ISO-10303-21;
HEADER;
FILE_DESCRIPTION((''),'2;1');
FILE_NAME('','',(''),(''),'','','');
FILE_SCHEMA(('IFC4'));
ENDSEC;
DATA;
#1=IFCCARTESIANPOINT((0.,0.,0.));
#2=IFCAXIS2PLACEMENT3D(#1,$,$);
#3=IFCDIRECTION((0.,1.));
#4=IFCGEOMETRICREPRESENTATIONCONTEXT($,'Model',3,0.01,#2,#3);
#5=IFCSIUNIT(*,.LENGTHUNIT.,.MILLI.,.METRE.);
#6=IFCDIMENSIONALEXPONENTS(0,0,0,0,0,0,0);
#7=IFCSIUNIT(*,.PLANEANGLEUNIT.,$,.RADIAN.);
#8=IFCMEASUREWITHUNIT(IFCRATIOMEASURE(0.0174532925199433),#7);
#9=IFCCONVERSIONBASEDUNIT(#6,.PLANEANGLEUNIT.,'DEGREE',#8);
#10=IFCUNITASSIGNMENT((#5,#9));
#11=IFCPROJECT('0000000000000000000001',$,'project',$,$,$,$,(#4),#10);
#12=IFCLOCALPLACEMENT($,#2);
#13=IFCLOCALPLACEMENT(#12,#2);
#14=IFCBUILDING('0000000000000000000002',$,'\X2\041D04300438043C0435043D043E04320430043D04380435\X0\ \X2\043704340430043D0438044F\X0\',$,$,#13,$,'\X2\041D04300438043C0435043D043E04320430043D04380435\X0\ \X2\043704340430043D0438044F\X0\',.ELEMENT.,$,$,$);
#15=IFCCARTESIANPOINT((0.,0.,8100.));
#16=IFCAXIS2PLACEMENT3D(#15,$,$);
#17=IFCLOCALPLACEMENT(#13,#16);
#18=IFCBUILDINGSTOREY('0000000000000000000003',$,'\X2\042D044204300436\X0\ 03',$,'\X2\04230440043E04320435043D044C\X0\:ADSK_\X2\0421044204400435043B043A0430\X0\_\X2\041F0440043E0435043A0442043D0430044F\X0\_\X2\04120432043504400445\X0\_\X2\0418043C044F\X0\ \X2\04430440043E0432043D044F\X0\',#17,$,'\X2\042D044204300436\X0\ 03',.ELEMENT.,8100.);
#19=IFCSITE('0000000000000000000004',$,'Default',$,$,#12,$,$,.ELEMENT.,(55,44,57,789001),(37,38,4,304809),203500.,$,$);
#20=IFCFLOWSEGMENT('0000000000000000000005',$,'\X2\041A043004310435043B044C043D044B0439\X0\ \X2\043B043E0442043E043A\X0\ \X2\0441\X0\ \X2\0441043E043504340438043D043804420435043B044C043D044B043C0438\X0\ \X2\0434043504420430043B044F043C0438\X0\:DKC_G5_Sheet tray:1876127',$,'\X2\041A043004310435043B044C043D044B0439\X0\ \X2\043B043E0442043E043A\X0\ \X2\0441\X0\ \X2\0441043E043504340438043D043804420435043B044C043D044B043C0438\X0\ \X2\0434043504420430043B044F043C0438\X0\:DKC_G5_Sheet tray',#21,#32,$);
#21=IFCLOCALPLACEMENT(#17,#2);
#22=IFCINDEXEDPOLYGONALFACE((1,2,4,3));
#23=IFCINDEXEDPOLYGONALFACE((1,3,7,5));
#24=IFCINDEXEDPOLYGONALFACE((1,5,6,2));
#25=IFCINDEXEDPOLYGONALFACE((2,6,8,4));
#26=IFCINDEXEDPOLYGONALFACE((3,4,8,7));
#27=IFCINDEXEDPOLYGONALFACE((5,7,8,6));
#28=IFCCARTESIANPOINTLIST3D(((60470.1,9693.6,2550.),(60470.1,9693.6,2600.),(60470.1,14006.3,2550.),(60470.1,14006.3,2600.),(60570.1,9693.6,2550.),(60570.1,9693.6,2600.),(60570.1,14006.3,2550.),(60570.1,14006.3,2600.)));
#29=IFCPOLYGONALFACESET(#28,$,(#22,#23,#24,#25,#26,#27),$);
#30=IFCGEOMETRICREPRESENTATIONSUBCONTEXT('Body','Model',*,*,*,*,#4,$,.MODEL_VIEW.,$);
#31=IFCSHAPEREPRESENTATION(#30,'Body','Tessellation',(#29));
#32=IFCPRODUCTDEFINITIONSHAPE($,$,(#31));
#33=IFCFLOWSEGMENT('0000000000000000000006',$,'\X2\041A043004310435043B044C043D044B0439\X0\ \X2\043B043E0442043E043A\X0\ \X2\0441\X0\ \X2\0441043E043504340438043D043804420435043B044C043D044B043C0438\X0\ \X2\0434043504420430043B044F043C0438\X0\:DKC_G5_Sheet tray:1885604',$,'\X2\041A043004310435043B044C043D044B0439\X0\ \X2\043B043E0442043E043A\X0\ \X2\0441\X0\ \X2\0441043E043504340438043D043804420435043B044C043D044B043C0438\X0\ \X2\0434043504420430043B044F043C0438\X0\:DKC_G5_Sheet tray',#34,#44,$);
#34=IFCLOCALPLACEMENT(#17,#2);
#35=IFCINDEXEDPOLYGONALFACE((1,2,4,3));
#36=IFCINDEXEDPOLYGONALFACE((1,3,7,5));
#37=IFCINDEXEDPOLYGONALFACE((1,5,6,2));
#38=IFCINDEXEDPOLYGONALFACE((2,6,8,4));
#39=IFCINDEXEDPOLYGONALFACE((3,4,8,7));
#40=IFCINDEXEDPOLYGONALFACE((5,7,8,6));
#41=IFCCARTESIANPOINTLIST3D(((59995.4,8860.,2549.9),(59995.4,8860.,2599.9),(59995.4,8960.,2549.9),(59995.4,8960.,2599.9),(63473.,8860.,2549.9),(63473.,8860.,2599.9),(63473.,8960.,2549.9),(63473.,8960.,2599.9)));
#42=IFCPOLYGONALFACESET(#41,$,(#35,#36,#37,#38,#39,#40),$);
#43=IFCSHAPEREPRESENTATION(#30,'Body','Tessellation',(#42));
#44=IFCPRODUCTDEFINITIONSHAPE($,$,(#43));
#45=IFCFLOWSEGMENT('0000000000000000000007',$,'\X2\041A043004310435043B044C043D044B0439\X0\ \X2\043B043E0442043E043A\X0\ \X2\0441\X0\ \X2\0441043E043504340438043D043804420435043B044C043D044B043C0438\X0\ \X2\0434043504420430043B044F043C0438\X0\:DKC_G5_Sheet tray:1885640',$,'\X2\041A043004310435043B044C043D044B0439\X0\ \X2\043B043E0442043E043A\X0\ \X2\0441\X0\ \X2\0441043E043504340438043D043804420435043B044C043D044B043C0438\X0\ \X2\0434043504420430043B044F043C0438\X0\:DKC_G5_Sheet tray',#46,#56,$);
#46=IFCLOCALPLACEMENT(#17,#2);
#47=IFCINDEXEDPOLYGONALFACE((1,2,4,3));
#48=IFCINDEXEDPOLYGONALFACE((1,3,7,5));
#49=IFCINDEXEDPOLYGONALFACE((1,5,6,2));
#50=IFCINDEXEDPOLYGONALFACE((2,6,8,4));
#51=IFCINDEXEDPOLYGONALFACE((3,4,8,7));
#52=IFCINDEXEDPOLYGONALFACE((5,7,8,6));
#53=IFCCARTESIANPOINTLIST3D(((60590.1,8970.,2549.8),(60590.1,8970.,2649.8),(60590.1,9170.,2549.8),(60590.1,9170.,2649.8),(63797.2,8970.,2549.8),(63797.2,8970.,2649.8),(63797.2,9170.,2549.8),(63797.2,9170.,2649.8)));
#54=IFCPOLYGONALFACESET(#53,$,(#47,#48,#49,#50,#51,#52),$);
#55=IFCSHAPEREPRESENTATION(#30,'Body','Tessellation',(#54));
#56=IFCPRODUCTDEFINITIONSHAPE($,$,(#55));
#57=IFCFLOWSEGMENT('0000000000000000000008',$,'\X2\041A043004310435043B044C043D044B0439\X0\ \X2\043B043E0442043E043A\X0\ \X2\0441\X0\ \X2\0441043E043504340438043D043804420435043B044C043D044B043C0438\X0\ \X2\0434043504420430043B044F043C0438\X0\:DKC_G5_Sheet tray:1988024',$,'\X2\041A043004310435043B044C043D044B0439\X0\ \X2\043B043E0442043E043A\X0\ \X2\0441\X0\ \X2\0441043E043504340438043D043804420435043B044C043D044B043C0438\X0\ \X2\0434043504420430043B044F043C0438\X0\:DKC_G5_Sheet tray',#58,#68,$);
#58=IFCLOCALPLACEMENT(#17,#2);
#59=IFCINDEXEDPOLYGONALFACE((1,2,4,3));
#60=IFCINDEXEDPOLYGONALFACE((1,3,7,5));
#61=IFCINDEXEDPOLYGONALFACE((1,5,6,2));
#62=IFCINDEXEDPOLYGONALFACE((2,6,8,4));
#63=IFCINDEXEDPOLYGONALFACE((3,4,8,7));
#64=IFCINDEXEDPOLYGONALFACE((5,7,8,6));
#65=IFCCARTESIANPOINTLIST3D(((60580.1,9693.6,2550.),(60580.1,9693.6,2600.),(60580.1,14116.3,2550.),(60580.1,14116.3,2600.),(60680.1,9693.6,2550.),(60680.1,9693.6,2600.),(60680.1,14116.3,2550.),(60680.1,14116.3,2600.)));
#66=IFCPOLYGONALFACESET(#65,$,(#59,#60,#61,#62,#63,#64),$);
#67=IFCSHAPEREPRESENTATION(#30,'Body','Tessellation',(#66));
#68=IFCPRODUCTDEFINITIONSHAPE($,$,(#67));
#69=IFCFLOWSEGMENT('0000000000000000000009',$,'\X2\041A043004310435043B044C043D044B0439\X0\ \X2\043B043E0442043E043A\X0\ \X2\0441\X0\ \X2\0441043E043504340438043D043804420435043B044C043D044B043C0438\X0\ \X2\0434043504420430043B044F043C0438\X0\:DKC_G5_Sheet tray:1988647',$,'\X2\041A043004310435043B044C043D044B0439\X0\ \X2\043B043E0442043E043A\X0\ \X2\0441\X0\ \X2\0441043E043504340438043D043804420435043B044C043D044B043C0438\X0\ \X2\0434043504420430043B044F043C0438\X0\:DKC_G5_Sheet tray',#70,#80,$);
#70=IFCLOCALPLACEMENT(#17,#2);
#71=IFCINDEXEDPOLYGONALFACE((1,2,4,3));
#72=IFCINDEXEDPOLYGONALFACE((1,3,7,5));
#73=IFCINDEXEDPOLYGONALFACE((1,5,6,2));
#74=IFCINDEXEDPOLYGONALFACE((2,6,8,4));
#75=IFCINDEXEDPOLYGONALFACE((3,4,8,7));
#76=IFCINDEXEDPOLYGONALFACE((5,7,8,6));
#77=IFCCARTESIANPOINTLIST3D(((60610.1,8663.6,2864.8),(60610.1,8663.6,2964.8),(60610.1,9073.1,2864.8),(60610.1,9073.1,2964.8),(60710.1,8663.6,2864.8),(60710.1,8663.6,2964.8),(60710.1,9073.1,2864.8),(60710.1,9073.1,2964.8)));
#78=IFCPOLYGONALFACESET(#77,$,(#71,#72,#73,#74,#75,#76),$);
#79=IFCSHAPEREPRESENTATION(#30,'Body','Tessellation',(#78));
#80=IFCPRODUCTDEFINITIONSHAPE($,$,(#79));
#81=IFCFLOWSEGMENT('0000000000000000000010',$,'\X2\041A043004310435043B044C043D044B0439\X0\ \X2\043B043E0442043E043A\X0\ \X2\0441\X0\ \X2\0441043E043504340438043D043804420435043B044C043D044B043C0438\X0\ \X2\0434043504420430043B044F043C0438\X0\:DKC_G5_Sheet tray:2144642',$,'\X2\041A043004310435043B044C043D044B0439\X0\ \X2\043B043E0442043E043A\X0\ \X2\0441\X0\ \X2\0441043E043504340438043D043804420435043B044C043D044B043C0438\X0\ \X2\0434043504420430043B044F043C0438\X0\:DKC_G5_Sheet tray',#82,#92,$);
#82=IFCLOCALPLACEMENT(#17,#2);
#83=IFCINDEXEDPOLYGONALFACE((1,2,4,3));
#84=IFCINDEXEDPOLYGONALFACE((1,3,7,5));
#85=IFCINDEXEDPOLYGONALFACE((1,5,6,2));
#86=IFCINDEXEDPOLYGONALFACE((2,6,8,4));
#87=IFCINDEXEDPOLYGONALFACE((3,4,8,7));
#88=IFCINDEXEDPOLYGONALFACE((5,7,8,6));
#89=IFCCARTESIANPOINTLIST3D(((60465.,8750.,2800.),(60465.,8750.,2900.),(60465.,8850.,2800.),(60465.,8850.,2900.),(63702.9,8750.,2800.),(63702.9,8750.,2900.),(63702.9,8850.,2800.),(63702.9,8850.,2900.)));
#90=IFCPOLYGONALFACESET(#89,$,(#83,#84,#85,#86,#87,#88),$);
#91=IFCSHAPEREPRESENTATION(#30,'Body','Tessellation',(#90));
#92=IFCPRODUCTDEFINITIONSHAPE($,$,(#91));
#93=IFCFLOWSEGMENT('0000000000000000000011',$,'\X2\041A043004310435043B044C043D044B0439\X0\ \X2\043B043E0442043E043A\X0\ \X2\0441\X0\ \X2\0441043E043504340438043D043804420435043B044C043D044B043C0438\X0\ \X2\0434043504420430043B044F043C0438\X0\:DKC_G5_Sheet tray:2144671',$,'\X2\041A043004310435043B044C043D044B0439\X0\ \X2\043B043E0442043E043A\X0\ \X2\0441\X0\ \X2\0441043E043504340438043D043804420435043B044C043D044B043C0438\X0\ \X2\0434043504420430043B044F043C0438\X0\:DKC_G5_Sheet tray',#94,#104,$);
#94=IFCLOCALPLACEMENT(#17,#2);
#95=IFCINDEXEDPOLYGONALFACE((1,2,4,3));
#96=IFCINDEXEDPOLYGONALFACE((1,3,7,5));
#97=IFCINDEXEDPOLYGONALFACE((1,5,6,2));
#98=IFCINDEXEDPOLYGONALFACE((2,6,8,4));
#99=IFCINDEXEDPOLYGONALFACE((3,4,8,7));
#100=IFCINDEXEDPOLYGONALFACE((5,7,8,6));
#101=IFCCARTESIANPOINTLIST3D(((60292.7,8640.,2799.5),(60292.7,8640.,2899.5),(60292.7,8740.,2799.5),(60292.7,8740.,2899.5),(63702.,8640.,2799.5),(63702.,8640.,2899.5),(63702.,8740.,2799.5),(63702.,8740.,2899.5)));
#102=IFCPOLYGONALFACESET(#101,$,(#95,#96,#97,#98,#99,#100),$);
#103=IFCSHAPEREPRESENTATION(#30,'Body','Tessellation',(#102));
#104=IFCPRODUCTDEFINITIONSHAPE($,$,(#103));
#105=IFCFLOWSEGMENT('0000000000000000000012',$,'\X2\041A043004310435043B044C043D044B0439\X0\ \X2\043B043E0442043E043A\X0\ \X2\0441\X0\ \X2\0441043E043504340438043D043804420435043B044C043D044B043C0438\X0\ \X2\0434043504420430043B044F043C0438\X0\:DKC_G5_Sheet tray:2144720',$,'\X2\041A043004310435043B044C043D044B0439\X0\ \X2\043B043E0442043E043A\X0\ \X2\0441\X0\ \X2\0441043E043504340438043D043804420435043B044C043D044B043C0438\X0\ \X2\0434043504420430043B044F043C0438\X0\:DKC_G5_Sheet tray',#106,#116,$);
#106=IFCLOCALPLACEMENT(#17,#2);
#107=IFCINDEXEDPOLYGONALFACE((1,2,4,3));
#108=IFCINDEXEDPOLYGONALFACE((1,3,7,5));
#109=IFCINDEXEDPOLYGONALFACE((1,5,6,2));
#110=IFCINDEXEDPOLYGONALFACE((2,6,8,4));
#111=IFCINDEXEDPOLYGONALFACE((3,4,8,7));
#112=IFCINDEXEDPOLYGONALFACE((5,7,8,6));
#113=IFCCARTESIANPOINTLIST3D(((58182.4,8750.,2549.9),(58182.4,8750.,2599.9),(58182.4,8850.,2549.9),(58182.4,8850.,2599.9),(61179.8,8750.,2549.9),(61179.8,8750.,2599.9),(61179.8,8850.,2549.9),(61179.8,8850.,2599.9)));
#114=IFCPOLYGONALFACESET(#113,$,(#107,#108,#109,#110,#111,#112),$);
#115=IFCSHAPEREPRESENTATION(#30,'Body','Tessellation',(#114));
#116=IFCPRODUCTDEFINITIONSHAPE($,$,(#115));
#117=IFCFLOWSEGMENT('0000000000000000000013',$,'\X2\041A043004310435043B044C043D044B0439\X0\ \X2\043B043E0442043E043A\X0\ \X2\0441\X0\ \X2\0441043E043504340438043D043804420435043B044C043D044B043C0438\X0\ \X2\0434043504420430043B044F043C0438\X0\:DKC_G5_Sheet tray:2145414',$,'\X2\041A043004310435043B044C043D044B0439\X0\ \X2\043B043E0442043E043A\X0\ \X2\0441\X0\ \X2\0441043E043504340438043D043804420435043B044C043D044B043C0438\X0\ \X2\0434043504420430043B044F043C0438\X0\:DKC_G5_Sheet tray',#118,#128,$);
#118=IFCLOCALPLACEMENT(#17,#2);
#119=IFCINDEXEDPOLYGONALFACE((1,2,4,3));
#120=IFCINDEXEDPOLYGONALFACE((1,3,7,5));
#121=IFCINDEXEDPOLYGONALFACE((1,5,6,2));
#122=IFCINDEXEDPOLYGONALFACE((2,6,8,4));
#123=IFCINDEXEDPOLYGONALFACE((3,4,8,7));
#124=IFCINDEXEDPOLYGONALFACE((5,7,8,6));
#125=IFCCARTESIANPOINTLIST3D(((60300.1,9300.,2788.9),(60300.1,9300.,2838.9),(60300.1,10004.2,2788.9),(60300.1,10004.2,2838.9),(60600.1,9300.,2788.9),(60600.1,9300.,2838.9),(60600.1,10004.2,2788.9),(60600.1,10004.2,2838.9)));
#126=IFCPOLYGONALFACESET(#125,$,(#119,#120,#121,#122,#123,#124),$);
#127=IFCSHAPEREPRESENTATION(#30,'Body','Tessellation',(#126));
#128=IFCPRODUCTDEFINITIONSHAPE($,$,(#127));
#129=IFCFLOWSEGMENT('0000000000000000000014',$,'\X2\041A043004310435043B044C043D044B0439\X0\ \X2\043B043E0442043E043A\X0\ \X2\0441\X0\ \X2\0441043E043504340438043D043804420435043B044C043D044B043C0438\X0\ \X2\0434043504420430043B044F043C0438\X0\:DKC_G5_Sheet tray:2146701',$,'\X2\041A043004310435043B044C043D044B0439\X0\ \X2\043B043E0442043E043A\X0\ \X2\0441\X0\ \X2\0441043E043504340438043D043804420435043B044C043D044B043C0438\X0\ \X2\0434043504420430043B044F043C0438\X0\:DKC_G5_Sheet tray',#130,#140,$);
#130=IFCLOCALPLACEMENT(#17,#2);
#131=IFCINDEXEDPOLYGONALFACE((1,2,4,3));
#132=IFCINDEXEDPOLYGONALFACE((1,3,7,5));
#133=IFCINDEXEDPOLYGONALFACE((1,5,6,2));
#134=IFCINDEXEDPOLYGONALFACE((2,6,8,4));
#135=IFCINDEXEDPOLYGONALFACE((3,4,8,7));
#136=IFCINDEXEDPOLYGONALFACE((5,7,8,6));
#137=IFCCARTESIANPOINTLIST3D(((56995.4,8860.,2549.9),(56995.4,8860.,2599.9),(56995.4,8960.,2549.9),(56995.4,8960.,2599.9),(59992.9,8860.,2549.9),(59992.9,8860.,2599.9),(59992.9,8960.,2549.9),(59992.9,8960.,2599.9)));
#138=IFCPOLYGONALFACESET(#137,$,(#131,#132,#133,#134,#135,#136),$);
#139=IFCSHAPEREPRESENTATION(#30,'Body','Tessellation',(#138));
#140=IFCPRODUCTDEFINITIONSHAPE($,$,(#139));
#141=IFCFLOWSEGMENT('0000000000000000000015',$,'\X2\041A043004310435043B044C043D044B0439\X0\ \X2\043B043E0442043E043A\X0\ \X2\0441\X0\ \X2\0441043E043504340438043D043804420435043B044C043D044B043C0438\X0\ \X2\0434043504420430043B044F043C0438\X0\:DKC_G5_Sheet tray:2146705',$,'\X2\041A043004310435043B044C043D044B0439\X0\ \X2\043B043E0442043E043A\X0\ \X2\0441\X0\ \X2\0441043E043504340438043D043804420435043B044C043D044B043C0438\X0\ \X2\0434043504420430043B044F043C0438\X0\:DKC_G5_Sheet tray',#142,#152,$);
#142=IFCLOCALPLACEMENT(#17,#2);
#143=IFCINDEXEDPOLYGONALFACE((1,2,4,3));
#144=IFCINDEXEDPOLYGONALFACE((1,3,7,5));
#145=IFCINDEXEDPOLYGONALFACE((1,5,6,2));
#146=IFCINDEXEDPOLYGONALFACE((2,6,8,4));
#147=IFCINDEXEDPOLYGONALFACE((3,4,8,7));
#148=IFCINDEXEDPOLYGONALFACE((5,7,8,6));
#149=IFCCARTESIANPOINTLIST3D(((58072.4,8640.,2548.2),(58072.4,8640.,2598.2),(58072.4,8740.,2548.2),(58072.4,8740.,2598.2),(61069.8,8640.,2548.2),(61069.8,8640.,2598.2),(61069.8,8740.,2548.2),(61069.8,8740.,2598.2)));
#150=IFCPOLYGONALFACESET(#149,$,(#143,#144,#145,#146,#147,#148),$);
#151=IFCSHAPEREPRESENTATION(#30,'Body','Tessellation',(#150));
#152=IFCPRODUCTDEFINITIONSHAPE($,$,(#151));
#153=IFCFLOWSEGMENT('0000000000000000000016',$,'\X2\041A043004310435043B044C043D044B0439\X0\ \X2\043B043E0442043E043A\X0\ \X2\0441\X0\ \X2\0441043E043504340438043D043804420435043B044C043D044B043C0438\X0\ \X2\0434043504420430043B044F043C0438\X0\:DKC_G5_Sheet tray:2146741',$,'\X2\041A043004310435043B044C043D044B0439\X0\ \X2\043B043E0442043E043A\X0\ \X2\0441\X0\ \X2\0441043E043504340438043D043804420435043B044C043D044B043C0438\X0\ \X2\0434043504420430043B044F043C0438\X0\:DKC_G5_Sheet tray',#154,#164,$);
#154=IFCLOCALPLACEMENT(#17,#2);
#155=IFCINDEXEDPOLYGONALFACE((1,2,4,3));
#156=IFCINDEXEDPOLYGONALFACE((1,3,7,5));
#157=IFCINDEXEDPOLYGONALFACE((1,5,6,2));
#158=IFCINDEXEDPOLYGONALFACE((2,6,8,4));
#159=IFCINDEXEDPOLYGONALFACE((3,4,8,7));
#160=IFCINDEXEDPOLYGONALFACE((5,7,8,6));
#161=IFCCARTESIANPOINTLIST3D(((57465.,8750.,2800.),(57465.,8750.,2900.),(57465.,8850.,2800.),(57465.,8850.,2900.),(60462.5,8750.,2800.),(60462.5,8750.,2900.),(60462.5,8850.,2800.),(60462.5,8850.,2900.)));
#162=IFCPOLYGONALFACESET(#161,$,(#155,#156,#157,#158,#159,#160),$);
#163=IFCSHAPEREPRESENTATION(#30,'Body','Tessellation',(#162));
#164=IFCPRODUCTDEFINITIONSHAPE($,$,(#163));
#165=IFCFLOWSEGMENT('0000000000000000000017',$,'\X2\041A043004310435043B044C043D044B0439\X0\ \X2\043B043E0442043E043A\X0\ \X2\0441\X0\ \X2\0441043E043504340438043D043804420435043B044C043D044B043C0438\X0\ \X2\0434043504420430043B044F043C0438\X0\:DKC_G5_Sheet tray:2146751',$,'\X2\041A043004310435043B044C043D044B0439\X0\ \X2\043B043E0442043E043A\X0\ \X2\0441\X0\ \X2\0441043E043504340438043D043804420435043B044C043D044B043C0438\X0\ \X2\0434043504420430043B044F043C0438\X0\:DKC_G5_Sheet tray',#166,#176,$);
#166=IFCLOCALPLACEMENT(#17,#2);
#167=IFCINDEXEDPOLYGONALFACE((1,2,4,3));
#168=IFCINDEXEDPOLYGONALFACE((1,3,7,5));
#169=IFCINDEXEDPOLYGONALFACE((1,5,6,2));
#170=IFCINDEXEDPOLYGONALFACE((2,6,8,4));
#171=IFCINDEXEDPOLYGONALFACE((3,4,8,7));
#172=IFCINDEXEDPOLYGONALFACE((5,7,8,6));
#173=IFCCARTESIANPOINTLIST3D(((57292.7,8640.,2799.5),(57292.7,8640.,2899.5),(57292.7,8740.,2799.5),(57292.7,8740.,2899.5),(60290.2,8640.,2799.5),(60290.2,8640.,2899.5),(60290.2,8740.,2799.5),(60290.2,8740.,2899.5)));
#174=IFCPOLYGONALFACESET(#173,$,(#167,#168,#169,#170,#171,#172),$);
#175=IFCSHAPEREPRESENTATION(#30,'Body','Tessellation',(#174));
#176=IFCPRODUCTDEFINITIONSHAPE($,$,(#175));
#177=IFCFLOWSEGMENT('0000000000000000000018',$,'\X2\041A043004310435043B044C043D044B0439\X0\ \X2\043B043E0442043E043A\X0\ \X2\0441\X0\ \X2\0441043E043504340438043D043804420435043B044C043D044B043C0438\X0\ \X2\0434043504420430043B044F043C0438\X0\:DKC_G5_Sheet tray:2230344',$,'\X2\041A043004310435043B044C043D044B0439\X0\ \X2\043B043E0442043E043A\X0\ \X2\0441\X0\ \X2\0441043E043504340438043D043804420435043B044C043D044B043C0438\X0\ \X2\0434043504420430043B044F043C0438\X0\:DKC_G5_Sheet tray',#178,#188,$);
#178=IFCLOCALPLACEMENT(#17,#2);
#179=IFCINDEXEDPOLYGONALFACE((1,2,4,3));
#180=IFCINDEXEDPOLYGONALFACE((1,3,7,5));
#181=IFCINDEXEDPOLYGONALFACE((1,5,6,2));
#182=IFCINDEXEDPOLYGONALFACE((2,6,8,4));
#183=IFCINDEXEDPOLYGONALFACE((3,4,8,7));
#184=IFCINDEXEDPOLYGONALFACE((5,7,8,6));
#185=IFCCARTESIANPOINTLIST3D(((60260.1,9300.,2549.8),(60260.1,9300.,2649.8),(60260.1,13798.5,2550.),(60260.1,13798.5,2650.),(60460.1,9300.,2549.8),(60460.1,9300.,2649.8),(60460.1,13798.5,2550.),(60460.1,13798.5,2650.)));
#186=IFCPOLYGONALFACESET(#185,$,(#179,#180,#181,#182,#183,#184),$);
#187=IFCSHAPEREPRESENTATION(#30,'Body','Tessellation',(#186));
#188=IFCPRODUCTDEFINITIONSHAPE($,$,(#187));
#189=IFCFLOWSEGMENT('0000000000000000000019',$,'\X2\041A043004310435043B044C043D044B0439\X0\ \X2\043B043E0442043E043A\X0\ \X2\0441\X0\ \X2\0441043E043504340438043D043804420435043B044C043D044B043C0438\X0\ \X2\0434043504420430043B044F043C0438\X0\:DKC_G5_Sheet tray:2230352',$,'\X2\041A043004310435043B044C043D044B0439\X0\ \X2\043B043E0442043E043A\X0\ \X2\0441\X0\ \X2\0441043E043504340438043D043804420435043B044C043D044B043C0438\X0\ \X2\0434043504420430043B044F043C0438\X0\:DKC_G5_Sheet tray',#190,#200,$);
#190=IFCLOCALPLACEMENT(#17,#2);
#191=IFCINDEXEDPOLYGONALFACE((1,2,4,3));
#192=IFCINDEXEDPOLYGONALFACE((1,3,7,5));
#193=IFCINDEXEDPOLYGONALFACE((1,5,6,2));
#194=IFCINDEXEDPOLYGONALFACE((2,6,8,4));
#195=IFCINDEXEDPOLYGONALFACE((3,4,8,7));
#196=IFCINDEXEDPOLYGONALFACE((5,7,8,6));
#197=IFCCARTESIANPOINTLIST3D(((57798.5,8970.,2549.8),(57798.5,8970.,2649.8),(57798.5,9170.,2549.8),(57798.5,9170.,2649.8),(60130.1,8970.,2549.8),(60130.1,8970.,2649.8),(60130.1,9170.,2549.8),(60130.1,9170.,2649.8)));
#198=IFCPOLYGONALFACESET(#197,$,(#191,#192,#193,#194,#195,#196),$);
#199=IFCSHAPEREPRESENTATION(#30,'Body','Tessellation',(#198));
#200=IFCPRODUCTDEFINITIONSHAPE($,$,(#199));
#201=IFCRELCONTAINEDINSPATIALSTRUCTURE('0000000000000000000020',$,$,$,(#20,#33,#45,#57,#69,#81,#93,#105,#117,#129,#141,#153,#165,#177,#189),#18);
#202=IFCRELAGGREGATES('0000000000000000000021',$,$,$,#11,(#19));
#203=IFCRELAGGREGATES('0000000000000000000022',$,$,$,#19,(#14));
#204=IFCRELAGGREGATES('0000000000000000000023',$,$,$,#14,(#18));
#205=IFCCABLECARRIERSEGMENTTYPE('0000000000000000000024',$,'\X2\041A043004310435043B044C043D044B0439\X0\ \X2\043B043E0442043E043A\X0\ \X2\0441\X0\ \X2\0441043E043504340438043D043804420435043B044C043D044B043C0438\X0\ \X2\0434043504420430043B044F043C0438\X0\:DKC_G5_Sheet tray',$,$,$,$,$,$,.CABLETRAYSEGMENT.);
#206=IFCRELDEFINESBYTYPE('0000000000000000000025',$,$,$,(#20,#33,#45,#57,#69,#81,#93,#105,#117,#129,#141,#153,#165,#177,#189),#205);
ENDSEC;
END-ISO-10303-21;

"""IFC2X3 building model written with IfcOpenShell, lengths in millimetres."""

from ifc_helpers import new_model, entity, si_unit, converted_unit, direction, frame, origin, origin_2d_with_axis, place, context, subcontext, project, spatial, rectangle, extrude, type_object, element, save


model = new_model("IFC2X3")

# Units and contexts
model_context = context("Model", 3, precision=0.01, world=origin(), true_north=direction((0.0, 1.0)))
body_context = subcontext(model_context, "Body", "Model", "MODEL_VIEW")
ifc_project = project(units=[si_unit("LENGTHUNIT", "METRE", prefix="MILLI"), converted_unit("PLANEANGLEUNIT", "DEGREE", entity("IfcRatioMeasure", 0.0174532925199433), si_unit("PLANEANGLEUNIT", "RADIAN"), dimensions=[0, 0, 0, 0, 0, 0, 0])], contexts=[model_context])

# Site, building, storey
site_placement = place(None, origin())
site = spatial("IfcSite", under=ifc_project, at=site_placement, Name="Default", CompositionType="ELEMENT", RefLatitude=(55, 44, 57, 789001), RefLongitude=(37, 38, 4, 304809), RefElevation=203500.0)
building_placement = place(site_placement, origin())
building = spatial("IfcBuilding", under=site, at=building_placement, Name="Наименование здания", LongName="Наименование здания", CompositionType="ELEMENT")
storey_placement = place(building_placement, frame((0.0, 0.0, 8100.0)))
storey = spatial("IfcBuildingStorey", under=building, at=storey_placement, Name="Этаж 03", ObjectType="Уровень:ADSK_Стрелка_Проектная_Вверх_Имя уровня", LongName="Этаж 03", CompositionType="ELEMENT", Elevation=8100.0)

# Flow segments
cable_carrier_segment_type = type_object("IfcCableCarrierSegmentType", Name="Кабельный лоток с соединительными деталями:DKC_G5_Sheet tray", PredefinedType="CABLETRAYSEGMENT")
flow_segment_1_placement = place(storey_placement, frame((60470.1, 9693.6, 2550.0)))
element("IfcFlowSegment", 1, at=flow_segment_1_placement, inside=storey, type_object=cable_carrier_segment_type, Name="Кабельный лоток с соединительными деталями:DKC_G5_Sheet tray:1876127", ObjectType="Кабельный лоток с соединительными деталями:DKC_G5_Sheet tray", context=body_context, shape_type="SweptSolid", body=[
    extrude(rectangle(XDim=4312.7, YDim=100.0, at=origin_2d_with_axis()), frame((50.0, 2156.3, 0.0), z_axis=(0.0, 0.0, 1.0), x_axis=(0.0, -1.0, 0.0)), (0.0, 0.0, 1.0), 50.0),
])
flow_segment_2_placement = place(storey_placement, frame((59995.4, 8860.0, 2549.9)))
element("IfcFlowSegment", 2, at=flow_segment_2_placement, inside=storey, type_object=cable_carrier_segment_type, Name="Кабельный лоток с соединительными деталями:DKC_G5_Sheet tray:1885604", ObjectType="Кабельный лоток с соединительными деталями:DKC_G5_Sheet tray", context=body_context, shape_type="SweptSolid", body=[
    extrude(rectangle(XDim=3477.6, YDim=100.0, at=origin_2d_with_axis()), frame((1738.8, 50.0, 0.0), z_axis=(0.0, 0.0, 1.0), x_axis=(-1.0, 0.0, 0.0)), (0.0, 0.0, 1.0), 50.0),
])
flow_segment_3_placement = place(storey_placement, frame((60590.1, 8970.0, 2549.8)))
element("IfcFlowSegment", 3, at=flow_segment_3_placement, inside=storey, type_object=cable_carrier_segment_type, Name="Кабельный лоток с соединительными деталями:DKC_G5_Sheet tray:1885640", ObjectType="Кабельный лоток с соединительными деталями:DKC_G5_Sheet tray", context=body_context, shape_type="SweptSolid", body=[
    extrude(rectangle(XDim=3207.1, YDim=200.0, at=origin_2d_with_axis()), frame((1603.5, 100.0, 0.0)), (0.0, 0.0, 1.0), 100.0),
])
flow_segment_4_placement = place(storey_placement, frame((60580.1, 9693.6, 2550.0)))
element("IfcFlowSegment", 4, at=flow_segment_4_placement, inside=storey, type_object=cable_carrier_segment_type, Name="Кабельный лоток с соединительными деталями:DKC_G5_Sheet tray:1988024", ObjectType="Кабельный лоток с соединительными деталями:DKC_G5_Sheet tray", context=body_context, shape_type="SweptSolid", body=[
    extrude(rectangle(XDim=4422.7, YDim=100.0, at=origin_2d_with_axis()), frame((50.0, 2211.3, 0.0), z_axis=(0.0, 0.0, 1.0), x_axis=(0.0, -1.0, 0.0)), (0.0, 0.0, 1.0), 50.0),
])
flow_segment_5_placement = place(storey_placement, frame((60610.1, 8663.6, 2864.8)))
element("IfcFlowSegment", 5, at=flow_segment_5_placement, inside=storey, type_object=cable_carrier_segment_type, Name="Кабельный лоток с соединительными деталями:DKC_G5_Sheet tray:1988647", ObjectType="Кабельный лоток с соединительными деталями:DKC_G5_Sheet tray", context=body_context, shape_type="SweptSolid", body=[
    extrude(rectangle(XDim=409.5, YDim=100.0, at=origin_2d_with_axis()), frame((50.0, 204.8, 0.0), z_axis=(0.0, 0.0, 1.0), x_axis=(0.0, -1.0, 0.0)), (0.0, 0.0, 1.0), 100.0),
])
flow_segment_6_placement = place(storey_placement, frame((60465.0, 8750.0, 2800.0)))
element("IfcFlowSegment", 6, at=flow_segment_6_placement, inside=storey, type_object=cable_carrier_segment_type, Name="Кабельный лоток с соединительными деталями:DKC_G5_Sheet tray:2144642", ObjectType="Кабельный лоток с соединительными деталями:DKC_G5_Sheet tray", context=body_context, shape_type="SweptSolid", body=[
    extrude(rectangle(XDim=3237.8, YDim=100.0, at=origin_2d_with_axis()), frame((1618.9, 50.0, 0.0), z_axis=(0.000001, 0.000012, 1.0), x_axis=(-1.0, 0.0, 0.000001)), (0.0, 0.0, 1.0), 100.0),
])
flow_segment_7_placement = place(storey_placement, frame((60292.7, 8640.0, 2799.5)))
element("IfcFlowSegment", 7, at=flow_segment_7_placement, inside=storey, type_object=cable_carrier_segment_type, Name="Кабельный лоток с соединительными деталями:DKC_G5_Sheet tray:2144671", ObjectType="Кабельный лоток с соединительными деталями:DKC_G5_Sheet tray", context=body_context, shape_type="SweptSolid", body=[
    extrude(rectangle(XDim=3409.3, YDim=100.0, at=origin_2d_with_axis()), frame((1704.6, 50.0, 0.0), z_axis=(0.0, -0.000024, 1.0), x_axis=(-1.0, 0.0, 0.0)), (0.0, 0.0, 1.0), 100.0),
])
flow_segment_8_placement = place(storey_placement, frame((58182.4, 8750.0, 2549.9)))
element("IfcFlowSegment", 8, at=flow_segment_8_placement, inside=storey, type_object=cable_carrier_segment_type, Name="Кабельный лоток с соединительными деталями:DKC_G5_Sheet tray:2144720", ObjectType="Кабельный лоток с соединительными деталями:DKC_G5_Sheet tray", context=body_context, shape_type="SweptSolid", body=[
    extrude(rectangle(XDim=2997.5, YDim=100.0, at=origin_2d_with_axis()), frame((1498.7, 50.0, 0.0)), (0.0, 0.0, 1.0), 50.0),
])
flow_segment_9_placement = place(storey_placement, frame((60300.1, 9300.0, 2788.9)))
element("IfcFlowSegment", 9, at=flow_segment_9_placement, inside=storey, type_object=cable_carrier_segment_type, Name="Кабельный лоток с соединительными деталями:DKC_G5_Sheet tray:2145414", ObjectType="Кабельный лоток с соединительными деталями:DKC_G5_Sheet tray", context=body_context, shape_type="SweptSolid", body=[
    extrude(rectangle(XDim=704.2, YDim=300.0, at=origin_2d_with_axis()), frame((150.0, 352.1, 0.0), z_axis=(0.0, 0.0, 1.0), x_axis=(0.0, 1.0, 0.0)), (0.0, 0.0, 1.0), 50.0),
])
flow_segment_10_placement = place(storey_placement, frame((56995.4, 8860.0, 2549.9)))
element("IfcFlowSegment", 10, at=flow_segment_10_placement, inside=storey, type_object=cable_carrier_segment_type, Name="Кабельный лоток с соединительными деталями:DKC_G5_Sheet tray:2146701", ObjectType="Кабельный лоток с соединительными деталями:DKC_G5_Sheet tray", context=body_context, shape_type="SweptSolid", body=[
    extrude(rectangle(XDim=2997.5, YDim=100.0, at=origin_2d_with_axis()), frame((1498.7, 50.0, 0.0), z_axis=(0.0, 0.0, 1.0), x_axis=(-1.0, 0.0, 0.0)), (0.0, 0.0, 1.0), 50.0),
])
flow_segment_11_placement = place(storey_placement, frame((58072.4, 8640.0, 2548.2)))
element("IfcFlowSegment", 11, at=flow_segment_11_placement, inside=storey, type_object=cable_carrier_segment_type, Name="Кабельный лоток с соединительными деталями:DKC_G5_Sheet tray:2146705", ObjectType="Кабельный лоток с соединительными деталями:DKC_G5_Sheet tray", context=body_context, shape_type="SweptSolid", body=[
    extrude(rectangle(XDim=2997.5, YDim=100.0, at=origin_2d_with_axis()), frame((1498.7, 50.0, 0.0)), (0.0, 0.0, 1.0), 50.0),
])
flow_segment_12_placement = place(storey_placement, frame((57465.0, 8750.0, 2800.0)))
element("IfcFlowSegment", 12, at=flow_segment_12_placement, inside=storey, type_object=cable_carrier_segment_type, Name="Кабельный лоток с соединительными деталями:DKC_G5_Sheet tray:2146741", ObjectType="Кабельный лоток с соединительными деталями:DKC_G5_Sheet tray", context=body_context, shape_type="SweptSolid", body=[
    extrude(rectangle(XDim=2997.5, YDim=100.0, at=origin_2d_with_axis()), frame((1498.7, 50.0, 0.0), z_axis=(0.000001, 0.0, 1.0), x_axis=(-1.0, 0.0, 0.000001)), (0.0, 0.0, 1.0), 100.0),
])
flow_segment_13_placement = place(storey_placement, frame((57292.7, 8640.0, 2799.5)))
element("IfcFlowSegment", 13, at=flow_segment_13_placement, inside=storey, type_object=cable_carrier_segment_type, Name="Кабельный лоток с соединительными деталями:DKC_G5_Sheet tray:2146751", ObjectType="Кабельный лоток с соединительными деталями:DKC_G5_Sheet tray", context=body_context, shape_type="SweptSolid", body=[
    extrude(rectangle(XDim=2997.5, YDim=100.0, at=origin_2d_with_axis()), frame((1498.7, 50.0, 0.0), z_axis=(0.0, 0.0, 1.0), x_axis=(-1.0, 0.0, 0.0)), (0.0, 0.0, 1.0), 100.0),
])
flow_segment_14_placement = place(storey_placement, frame((60260.1, 9300.0, 2549.8)))
element("IfcFlowSegment", 14, at=flow_segment_14_placement, inside=storey, type_object=cable_carrier_segment_type, Name="Кабельный лоток с соединительными деталями:DKC_G5_Sheet tray:2230344", ObjectType="Кабельный лоток с соединительными деталями:DKC_G5_Sheet tray", context=body_context, shape_type="SweptSolid", body=[
    extrude(rectangle(XDim=4498.5, YDim=200.0, at=origin_2d_with_axis()), frame((100.0, 2249.3, 0.1), z_axis=(0.0, -0.000032, 1.0), x_axis=(0.0, 1.0, 0.000032)), (0.0, 0.0, 1.0), 100.0),
])
flow_segment_15_placement = place(storey_placement, frame((57798.5, 8970.0, 2549.8)))
element("IfcFlowSegment", 15, at=flow_segment_15_placement, inside=storey, type_object=cable_carrier_segment_type, Name="Кабельный лоток с соединительными деталями:DKC_G5_Sheet tray:2230352", ObjectType="Кабельный лоток с соединительными деталями:DKC_G5_Sheet tray", context=body_context, shape_type="SweptSolid", body=[
    extrude(rectangle(XDim=2331.7, YDim=200.0, at=origin_2d_with_axis()), frame((1165.8, 100.0, 0.0)), (0.0, 0.0, 1.0), 100.0),
])

save(model, "model.ifc")
